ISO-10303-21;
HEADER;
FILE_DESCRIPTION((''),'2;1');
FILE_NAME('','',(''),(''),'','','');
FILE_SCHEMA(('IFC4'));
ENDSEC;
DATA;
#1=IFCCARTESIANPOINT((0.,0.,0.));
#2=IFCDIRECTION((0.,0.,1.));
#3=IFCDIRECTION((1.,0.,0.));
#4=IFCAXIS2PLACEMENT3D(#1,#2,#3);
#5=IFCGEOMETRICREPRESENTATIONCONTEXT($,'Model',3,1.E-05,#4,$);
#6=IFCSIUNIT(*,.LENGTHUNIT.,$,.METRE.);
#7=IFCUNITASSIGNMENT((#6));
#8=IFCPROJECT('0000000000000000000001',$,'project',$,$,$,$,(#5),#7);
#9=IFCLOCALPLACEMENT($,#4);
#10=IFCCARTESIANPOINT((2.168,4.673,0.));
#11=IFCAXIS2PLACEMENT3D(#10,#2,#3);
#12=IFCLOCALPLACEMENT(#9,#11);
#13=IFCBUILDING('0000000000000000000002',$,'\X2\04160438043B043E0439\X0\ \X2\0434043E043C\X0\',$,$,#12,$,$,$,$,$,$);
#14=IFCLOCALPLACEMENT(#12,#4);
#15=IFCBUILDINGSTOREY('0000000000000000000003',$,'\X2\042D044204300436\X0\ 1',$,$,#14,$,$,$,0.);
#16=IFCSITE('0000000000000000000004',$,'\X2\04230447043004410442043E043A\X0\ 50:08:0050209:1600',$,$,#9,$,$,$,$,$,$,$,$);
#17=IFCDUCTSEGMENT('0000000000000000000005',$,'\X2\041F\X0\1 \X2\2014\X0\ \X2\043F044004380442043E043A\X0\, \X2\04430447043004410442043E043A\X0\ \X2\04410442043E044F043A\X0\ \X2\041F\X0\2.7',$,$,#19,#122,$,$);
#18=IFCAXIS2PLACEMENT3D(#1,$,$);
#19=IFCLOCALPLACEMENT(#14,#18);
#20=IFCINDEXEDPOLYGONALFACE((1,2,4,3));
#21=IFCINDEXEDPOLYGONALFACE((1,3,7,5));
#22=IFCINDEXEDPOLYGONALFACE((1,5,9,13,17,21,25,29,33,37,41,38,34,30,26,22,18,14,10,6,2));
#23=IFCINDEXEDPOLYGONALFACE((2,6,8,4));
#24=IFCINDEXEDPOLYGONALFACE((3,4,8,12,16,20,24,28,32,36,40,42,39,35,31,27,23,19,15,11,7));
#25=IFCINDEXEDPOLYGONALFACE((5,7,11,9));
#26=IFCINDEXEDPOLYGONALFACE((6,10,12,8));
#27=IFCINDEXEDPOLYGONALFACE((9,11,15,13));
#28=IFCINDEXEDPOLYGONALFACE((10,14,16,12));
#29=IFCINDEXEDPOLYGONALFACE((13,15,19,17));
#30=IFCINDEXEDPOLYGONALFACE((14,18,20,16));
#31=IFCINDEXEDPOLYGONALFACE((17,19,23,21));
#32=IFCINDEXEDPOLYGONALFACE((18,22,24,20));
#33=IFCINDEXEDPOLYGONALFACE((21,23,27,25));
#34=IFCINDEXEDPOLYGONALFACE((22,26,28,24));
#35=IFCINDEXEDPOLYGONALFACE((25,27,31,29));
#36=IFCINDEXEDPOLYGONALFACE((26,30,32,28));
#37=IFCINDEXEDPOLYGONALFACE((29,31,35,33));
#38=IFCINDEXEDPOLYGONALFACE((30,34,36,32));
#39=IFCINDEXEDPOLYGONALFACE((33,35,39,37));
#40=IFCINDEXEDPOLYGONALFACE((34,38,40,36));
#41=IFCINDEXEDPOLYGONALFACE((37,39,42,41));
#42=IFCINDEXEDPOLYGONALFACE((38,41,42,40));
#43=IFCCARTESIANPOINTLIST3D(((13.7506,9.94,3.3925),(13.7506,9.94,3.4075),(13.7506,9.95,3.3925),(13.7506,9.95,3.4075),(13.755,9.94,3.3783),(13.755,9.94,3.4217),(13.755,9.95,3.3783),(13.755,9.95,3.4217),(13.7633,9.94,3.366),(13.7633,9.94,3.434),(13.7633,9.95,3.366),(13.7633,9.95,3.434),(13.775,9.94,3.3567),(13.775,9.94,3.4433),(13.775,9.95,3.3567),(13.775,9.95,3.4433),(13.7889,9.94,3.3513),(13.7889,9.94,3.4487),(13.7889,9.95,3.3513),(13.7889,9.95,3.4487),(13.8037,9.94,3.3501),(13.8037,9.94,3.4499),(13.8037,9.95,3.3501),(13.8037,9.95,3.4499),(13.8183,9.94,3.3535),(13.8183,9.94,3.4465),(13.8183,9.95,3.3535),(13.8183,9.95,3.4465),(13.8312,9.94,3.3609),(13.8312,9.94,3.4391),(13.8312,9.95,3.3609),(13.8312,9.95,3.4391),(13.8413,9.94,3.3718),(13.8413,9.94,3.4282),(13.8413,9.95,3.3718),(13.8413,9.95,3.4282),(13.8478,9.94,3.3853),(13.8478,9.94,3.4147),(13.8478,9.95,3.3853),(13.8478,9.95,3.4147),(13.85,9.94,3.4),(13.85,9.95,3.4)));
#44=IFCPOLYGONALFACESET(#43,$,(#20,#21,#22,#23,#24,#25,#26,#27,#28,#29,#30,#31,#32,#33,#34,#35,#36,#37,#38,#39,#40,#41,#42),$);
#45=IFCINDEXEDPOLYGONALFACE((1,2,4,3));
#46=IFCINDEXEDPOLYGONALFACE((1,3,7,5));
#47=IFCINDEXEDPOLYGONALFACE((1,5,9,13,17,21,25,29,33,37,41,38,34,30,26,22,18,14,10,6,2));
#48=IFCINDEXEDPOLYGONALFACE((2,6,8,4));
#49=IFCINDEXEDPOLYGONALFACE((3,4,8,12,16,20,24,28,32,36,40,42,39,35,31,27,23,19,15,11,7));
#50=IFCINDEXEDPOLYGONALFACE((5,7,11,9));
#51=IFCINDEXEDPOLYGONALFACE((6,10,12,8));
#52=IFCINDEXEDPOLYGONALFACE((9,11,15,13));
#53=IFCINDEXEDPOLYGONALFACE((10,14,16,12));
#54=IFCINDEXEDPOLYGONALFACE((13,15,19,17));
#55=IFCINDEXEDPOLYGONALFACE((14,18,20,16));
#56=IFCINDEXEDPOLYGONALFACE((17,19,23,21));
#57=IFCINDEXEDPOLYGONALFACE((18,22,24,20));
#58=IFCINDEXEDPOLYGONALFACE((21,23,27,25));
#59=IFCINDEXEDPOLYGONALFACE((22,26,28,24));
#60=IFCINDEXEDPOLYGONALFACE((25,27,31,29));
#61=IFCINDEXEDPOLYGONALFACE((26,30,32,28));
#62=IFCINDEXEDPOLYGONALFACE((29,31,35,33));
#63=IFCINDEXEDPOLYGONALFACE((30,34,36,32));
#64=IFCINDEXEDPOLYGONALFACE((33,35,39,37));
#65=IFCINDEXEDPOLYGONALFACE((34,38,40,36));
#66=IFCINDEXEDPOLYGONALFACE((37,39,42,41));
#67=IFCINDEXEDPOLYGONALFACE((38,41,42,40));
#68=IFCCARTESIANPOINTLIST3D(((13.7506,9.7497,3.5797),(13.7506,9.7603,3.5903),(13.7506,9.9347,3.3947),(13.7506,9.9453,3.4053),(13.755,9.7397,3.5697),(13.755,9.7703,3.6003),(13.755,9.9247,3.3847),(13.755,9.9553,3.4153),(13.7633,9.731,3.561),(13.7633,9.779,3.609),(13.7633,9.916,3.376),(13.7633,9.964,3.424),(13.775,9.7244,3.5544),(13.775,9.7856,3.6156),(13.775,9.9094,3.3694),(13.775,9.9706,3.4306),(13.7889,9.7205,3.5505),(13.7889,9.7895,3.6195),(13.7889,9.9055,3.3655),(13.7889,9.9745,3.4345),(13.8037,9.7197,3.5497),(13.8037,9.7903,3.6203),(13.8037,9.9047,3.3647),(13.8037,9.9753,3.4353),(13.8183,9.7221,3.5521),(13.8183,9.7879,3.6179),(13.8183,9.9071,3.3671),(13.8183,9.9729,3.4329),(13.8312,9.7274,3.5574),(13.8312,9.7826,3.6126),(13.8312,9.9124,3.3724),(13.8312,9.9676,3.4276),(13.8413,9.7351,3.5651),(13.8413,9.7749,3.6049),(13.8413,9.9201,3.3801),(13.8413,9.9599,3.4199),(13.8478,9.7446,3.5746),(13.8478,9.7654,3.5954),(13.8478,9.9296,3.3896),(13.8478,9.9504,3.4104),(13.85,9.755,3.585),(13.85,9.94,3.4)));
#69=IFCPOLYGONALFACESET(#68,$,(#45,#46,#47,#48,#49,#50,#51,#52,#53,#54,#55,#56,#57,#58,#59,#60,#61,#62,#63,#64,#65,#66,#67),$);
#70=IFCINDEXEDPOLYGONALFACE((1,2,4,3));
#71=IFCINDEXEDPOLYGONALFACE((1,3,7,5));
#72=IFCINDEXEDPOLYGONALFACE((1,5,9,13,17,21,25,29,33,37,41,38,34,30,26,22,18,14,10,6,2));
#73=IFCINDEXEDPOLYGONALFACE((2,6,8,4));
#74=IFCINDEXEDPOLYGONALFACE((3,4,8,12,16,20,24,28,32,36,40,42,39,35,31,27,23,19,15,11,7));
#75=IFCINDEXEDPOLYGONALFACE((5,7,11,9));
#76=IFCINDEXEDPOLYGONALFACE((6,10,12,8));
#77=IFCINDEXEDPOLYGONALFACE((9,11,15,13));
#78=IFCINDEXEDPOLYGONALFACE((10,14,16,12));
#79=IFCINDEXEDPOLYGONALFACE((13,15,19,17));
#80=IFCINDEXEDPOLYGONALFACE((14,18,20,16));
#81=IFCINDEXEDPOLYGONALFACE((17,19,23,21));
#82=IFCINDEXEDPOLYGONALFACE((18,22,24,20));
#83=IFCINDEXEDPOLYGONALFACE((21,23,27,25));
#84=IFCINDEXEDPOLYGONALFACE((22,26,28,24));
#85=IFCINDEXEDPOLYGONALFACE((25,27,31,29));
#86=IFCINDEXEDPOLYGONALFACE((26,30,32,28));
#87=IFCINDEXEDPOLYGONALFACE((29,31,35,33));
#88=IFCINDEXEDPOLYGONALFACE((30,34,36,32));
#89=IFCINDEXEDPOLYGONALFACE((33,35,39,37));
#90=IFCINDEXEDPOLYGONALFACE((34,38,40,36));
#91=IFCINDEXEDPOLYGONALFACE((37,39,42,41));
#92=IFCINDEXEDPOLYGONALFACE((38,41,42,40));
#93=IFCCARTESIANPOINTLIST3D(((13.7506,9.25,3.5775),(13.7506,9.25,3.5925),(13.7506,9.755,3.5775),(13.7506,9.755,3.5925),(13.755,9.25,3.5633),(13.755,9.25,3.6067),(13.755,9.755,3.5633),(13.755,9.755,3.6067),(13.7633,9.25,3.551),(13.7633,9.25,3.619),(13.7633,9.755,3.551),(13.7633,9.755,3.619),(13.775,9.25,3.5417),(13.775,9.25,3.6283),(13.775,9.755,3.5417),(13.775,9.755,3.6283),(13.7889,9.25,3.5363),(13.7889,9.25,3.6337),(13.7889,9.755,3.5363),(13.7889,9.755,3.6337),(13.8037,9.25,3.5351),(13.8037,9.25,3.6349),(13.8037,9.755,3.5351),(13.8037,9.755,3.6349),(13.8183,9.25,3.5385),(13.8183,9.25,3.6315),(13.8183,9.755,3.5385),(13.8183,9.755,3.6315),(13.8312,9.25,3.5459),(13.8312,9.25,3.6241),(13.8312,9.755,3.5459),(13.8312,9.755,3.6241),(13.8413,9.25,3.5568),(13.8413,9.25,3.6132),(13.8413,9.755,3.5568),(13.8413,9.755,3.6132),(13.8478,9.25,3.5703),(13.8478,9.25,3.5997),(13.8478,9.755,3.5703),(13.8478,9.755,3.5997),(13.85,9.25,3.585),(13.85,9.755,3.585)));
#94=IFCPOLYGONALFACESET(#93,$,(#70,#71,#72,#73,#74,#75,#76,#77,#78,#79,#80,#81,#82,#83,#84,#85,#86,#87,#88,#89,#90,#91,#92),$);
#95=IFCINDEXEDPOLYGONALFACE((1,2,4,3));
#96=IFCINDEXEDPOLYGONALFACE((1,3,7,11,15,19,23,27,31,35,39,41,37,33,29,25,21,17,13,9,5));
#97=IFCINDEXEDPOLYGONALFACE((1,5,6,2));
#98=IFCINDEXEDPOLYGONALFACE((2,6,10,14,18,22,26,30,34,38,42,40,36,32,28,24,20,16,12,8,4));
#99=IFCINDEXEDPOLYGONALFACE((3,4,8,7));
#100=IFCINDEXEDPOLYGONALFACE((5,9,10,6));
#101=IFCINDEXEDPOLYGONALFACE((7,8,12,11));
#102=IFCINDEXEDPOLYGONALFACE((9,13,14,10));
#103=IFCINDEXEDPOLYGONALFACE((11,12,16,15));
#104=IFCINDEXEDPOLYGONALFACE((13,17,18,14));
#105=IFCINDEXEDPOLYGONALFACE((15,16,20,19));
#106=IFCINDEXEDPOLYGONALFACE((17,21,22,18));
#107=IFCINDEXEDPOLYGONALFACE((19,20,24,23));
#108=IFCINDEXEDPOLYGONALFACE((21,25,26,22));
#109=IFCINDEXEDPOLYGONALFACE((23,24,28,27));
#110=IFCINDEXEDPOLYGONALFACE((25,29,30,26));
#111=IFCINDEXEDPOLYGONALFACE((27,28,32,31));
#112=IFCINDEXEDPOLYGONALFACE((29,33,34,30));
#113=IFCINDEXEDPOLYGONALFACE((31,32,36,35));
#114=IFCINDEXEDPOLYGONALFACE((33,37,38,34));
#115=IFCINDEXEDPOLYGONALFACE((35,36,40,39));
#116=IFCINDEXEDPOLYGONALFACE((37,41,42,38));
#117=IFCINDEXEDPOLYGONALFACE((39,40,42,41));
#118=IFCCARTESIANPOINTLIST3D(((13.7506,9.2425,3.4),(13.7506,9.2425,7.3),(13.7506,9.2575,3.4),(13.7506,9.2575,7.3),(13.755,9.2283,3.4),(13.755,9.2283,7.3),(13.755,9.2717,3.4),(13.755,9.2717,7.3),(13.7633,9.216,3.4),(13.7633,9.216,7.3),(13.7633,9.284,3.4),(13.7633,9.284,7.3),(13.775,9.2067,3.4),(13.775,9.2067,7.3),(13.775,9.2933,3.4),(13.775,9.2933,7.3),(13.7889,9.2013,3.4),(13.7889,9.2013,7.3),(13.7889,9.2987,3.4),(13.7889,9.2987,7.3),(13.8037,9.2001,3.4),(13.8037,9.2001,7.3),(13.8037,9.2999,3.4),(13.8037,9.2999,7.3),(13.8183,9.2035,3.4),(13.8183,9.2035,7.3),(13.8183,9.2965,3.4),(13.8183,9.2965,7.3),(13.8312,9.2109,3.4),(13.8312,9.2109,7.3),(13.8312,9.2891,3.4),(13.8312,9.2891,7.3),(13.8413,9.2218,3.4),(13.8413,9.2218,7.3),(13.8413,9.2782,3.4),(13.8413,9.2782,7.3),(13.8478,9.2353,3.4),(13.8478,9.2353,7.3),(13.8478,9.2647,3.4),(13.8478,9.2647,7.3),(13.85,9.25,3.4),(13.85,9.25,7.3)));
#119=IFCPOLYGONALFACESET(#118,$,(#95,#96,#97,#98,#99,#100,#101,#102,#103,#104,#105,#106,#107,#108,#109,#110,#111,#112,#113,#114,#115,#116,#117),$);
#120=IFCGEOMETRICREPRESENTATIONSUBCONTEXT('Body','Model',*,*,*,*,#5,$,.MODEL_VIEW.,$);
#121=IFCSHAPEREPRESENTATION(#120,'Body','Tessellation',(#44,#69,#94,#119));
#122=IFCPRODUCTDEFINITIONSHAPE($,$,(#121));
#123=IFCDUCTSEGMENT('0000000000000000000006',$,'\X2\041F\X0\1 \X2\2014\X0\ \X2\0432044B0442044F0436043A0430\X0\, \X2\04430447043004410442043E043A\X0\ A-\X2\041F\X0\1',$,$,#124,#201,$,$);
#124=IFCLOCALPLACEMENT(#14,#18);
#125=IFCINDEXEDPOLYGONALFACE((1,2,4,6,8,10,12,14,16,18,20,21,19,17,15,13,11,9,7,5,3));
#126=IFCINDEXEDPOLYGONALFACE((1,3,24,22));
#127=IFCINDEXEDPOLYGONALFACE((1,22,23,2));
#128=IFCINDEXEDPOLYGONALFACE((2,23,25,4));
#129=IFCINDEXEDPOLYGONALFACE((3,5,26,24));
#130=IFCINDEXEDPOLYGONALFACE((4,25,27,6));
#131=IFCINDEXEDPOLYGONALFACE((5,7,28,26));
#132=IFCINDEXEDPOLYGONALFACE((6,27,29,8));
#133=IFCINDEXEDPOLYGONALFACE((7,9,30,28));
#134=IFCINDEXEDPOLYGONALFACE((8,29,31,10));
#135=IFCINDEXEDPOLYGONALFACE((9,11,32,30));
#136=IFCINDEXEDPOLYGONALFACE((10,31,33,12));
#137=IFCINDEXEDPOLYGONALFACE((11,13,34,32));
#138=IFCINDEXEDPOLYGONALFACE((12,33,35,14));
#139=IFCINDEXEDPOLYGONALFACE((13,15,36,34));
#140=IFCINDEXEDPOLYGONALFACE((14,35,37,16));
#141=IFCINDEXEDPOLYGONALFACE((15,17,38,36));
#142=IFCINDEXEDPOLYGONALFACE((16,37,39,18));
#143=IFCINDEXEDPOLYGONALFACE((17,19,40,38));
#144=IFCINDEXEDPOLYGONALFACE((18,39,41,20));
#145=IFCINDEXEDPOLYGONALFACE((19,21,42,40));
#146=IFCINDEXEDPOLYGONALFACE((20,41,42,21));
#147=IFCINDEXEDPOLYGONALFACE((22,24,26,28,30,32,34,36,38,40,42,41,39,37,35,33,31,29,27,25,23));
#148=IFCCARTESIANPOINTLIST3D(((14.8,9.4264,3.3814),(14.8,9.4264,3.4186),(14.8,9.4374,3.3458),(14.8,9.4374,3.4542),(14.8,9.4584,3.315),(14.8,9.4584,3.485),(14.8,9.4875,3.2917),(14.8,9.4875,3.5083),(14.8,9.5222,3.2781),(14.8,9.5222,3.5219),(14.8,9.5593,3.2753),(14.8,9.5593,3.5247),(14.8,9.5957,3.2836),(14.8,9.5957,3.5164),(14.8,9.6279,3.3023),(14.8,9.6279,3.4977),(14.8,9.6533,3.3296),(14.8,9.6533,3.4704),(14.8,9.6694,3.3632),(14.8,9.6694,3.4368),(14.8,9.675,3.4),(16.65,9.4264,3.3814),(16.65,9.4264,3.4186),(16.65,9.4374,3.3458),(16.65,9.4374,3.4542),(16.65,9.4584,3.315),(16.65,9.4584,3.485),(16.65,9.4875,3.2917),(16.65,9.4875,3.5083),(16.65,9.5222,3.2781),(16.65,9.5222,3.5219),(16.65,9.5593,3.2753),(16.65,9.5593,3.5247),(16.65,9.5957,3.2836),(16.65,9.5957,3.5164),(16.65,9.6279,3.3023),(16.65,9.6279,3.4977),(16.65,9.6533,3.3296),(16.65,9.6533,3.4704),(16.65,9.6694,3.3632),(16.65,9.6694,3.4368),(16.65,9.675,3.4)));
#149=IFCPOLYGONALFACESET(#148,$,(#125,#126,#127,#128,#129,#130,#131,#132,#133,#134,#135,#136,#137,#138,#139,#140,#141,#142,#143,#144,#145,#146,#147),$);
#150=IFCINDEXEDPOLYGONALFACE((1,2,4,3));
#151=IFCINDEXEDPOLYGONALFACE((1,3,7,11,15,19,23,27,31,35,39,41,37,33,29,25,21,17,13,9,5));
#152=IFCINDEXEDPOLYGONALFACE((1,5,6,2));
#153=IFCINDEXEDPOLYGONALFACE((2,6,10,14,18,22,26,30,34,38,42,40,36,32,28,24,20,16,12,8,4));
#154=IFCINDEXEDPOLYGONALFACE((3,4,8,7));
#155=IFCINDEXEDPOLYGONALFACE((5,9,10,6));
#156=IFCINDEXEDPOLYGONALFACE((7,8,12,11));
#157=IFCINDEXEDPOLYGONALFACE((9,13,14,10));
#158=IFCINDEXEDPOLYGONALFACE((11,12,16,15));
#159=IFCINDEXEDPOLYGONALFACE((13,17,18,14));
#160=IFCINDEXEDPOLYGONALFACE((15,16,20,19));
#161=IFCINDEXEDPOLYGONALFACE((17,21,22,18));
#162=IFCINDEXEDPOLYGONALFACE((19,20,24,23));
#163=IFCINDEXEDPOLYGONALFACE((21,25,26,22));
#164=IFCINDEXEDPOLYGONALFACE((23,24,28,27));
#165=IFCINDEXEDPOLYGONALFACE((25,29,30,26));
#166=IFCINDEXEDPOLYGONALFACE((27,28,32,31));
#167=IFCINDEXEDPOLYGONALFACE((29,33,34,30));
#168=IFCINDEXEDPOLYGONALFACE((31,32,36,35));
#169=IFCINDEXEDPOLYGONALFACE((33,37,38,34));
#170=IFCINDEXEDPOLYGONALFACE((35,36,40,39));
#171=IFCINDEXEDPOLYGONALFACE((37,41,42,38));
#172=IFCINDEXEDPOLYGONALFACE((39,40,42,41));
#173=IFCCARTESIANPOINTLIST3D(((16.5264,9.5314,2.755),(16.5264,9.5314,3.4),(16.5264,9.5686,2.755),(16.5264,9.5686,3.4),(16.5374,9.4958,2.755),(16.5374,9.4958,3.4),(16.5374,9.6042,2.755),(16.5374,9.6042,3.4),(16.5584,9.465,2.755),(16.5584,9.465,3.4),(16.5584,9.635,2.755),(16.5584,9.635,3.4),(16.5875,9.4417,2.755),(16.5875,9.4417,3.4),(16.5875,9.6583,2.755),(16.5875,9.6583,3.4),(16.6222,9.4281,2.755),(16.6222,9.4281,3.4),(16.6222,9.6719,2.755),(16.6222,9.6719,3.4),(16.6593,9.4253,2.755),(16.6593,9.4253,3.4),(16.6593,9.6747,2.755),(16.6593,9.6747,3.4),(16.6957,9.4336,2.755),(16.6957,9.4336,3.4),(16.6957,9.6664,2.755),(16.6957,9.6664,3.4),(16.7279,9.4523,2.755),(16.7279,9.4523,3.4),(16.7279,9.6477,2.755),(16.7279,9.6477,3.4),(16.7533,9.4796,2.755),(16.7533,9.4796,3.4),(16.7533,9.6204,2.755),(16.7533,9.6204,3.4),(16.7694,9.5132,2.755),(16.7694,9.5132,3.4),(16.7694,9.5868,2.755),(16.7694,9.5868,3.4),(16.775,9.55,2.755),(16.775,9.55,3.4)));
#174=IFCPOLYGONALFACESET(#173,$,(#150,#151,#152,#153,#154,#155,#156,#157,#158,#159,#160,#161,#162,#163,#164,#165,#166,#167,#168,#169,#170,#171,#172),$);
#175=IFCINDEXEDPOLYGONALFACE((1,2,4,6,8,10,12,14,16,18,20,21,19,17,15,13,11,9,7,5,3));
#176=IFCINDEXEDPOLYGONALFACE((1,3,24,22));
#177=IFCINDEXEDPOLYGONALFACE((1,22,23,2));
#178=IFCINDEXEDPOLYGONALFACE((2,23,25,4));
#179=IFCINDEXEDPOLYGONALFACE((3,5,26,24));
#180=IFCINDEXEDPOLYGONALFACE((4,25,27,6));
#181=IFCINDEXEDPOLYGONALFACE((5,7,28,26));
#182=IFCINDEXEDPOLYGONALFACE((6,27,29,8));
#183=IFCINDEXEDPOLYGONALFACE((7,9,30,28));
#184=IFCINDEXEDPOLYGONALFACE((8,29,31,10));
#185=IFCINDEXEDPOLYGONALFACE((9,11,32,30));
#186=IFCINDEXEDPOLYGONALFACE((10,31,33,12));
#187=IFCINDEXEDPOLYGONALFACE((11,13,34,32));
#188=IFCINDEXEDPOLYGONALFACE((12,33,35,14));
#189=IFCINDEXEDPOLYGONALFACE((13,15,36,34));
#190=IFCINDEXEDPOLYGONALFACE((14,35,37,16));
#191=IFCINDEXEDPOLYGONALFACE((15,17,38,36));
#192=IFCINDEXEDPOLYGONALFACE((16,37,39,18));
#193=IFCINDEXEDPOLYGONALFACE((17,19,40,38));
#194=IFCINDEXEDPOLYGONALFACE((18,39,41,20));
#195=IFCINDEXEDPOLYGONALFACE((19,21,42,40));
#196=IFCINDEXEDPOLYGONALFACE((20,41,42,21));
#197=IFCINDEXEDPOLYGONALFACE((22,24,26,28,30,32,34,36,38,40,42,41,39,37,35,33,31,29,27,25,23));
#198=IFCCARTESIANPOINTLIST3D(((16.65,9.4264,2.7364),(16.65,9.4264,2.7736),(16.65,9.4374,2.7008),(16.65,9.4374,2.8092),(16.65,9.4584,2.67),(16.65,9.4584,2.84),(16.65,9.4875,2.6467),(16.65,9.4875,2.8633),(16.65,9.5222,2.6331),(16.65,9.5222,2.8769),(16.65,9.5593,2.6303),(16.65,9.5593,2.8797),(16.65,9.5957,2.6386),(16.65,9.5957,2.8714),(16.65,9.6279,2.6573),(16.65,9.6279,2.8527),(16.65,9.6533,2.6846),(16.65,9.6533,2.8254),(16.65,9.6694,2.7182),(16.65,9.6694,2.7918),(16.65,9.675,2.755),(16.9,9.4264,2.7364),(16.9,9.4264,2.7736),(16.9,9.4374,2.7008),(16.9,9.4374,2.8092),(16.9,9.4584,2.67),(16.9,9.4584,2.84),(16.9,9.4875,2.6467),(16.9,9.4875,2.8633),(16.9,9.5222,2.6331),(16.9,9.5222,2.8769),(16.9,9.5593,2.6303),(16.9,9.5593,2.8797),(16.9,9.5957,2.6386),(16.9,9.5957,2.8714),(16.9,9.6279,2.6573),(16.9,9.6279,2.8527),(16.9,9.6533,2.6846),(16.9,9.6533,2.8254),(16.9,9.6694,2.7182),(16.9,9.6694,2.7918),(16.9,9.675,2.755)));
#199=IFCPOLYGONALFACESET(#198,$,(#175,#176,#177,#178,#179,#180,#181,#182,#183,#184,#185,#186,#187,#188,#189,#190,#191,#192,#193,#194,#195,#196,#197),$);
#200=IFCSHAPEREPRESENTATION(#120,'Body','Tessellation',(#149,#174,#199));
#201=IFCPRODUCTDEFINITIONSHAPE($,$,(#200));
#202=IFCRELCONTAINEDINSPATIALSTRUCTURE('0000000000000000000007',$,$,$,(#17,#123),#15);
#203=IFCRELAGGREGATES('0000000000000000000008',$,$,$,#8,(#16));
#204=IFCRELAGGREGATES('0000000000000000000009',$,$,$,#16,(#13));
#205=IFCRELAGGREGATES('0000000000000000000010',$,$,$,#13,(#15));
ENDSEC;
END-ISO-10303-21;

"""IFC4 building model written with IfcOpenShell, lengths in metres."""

from ifc_helpers import new_model, si_unit, frame, origin_with_axes, origin_2d, place, context, subcontext, project, spatial, circle, extrude, element, save


model = new_model("IFC4")

# Units and contexts
model_context = context("Model", 3, precision=1e-05, world=origin_with_axes())
body_context = subcontext(model_context, "Body", "Model", "MODEL_VIEW")
ifc_project = project(units=[si_unit("LENGTHUNIT", "METRE")], contexts=[model_context])

# Site, building, storey
site_placement = place(None, origin_with_axes())
site = spatial("IfcSite", under=ifc_project, at=site_placement, Name="Участок 50:08:0050209:1600")
building_placement = place(site_placement, frame((2.168, 4.673, 0.0), z_axis=(0.0, 0.0, 1.0), x_axis=(1.0, 0.0, 0.0)))
building = spatial("IfcBuilding", under=site, at=building_placement, Name="Жилой дом")
storey_placement = place(building_placement, origin_with_axes())
storey = spatial("IfcBuildingStorey", under=building, at=storey_placement, Name="Этаж 1", Elevation=0.0)

# Duct segments
duct_segment_1_placement = place(storey_placement, origin_with_axes())
element("IfcDuctSegment", 1, at=duct_segment_1_placement, inside=storey, Name="П1 — приток, участок стояк П2.7", context=body_context, shape_type="SweptSolid", body=[
    extrude(circle(Radius=0.05, at=origin_2d()), frame((13.8, 9.95, 3.4), z_axis=(0.0, -1.0, 0.0), x_axis=(1.0, 0.0, 0.0)), (0.0, 0.0, 1.0), 0.01),
    extrude(circle(Radius=0.05, at=origin_2d()), frame((13.8, 9.94, 3.4), z_axis=(0.0, -0.707107, 0.707107), x_axis=(1.0, 0.0, 0.0)), (0.0, 0.0, 1.0), 0.2616),
    extrude(circle(Radius=0.05, at=origin_2d()), frame((13.8, 9.755, 3.585), z_axis=(0.0, -1.0, 0.0), x_axis=(1.0, 0.0, 0.0)), (0.0, 0.0, 1.0), 0.505),
    extrude(circle(Radius=0.05, at=origin_2d()), frame((13.8, 9.25, 3.4), z_axis=(0.0, 0.0, 1.0), x_axis=(1.0, 0.0, 0.0)), (0.0, 0.0, 1.0), 3.9),
])
duct_segment_2_placement = place(storey_placement, origin_with_axes())
element("IfcDuctSegment", 2, at=duct_segment_2_placement, inside=storey, Name="П1 — вытяжка, участок A-П1", context=body_context, shape_type="SweptSolid", body=[
    extrude(circle(Radius=0.125, at=origin_2d()), frame((14.8, 9.55, 3.4), z_axis=(1.0, 0.0, 0.0), x_axis=(0.0, 1.0, 0.0)), (0.0, 0.0, 1.0), 1.85),
    extrude(circle(Radius=0.125, at=origin_2d()), frame((16.65, 9.55, 3.4), z_axis=(0.0, 0.0, -1.0), x_axis=(1.0, 0.0, 0.0)), (0.0, 0.0, 1.0), 0.645),
    extrude(circle(Radius=0.125, at=origin_2d()), frame((16.65, 9.55, 2.755), z_axis=(1.0, 0.0, 0.0), x_axis=(0.0, 1.0, 0.0)), (0.0, 0.0, 1.0), 0.25),
])

save(model, "model.ifc")
